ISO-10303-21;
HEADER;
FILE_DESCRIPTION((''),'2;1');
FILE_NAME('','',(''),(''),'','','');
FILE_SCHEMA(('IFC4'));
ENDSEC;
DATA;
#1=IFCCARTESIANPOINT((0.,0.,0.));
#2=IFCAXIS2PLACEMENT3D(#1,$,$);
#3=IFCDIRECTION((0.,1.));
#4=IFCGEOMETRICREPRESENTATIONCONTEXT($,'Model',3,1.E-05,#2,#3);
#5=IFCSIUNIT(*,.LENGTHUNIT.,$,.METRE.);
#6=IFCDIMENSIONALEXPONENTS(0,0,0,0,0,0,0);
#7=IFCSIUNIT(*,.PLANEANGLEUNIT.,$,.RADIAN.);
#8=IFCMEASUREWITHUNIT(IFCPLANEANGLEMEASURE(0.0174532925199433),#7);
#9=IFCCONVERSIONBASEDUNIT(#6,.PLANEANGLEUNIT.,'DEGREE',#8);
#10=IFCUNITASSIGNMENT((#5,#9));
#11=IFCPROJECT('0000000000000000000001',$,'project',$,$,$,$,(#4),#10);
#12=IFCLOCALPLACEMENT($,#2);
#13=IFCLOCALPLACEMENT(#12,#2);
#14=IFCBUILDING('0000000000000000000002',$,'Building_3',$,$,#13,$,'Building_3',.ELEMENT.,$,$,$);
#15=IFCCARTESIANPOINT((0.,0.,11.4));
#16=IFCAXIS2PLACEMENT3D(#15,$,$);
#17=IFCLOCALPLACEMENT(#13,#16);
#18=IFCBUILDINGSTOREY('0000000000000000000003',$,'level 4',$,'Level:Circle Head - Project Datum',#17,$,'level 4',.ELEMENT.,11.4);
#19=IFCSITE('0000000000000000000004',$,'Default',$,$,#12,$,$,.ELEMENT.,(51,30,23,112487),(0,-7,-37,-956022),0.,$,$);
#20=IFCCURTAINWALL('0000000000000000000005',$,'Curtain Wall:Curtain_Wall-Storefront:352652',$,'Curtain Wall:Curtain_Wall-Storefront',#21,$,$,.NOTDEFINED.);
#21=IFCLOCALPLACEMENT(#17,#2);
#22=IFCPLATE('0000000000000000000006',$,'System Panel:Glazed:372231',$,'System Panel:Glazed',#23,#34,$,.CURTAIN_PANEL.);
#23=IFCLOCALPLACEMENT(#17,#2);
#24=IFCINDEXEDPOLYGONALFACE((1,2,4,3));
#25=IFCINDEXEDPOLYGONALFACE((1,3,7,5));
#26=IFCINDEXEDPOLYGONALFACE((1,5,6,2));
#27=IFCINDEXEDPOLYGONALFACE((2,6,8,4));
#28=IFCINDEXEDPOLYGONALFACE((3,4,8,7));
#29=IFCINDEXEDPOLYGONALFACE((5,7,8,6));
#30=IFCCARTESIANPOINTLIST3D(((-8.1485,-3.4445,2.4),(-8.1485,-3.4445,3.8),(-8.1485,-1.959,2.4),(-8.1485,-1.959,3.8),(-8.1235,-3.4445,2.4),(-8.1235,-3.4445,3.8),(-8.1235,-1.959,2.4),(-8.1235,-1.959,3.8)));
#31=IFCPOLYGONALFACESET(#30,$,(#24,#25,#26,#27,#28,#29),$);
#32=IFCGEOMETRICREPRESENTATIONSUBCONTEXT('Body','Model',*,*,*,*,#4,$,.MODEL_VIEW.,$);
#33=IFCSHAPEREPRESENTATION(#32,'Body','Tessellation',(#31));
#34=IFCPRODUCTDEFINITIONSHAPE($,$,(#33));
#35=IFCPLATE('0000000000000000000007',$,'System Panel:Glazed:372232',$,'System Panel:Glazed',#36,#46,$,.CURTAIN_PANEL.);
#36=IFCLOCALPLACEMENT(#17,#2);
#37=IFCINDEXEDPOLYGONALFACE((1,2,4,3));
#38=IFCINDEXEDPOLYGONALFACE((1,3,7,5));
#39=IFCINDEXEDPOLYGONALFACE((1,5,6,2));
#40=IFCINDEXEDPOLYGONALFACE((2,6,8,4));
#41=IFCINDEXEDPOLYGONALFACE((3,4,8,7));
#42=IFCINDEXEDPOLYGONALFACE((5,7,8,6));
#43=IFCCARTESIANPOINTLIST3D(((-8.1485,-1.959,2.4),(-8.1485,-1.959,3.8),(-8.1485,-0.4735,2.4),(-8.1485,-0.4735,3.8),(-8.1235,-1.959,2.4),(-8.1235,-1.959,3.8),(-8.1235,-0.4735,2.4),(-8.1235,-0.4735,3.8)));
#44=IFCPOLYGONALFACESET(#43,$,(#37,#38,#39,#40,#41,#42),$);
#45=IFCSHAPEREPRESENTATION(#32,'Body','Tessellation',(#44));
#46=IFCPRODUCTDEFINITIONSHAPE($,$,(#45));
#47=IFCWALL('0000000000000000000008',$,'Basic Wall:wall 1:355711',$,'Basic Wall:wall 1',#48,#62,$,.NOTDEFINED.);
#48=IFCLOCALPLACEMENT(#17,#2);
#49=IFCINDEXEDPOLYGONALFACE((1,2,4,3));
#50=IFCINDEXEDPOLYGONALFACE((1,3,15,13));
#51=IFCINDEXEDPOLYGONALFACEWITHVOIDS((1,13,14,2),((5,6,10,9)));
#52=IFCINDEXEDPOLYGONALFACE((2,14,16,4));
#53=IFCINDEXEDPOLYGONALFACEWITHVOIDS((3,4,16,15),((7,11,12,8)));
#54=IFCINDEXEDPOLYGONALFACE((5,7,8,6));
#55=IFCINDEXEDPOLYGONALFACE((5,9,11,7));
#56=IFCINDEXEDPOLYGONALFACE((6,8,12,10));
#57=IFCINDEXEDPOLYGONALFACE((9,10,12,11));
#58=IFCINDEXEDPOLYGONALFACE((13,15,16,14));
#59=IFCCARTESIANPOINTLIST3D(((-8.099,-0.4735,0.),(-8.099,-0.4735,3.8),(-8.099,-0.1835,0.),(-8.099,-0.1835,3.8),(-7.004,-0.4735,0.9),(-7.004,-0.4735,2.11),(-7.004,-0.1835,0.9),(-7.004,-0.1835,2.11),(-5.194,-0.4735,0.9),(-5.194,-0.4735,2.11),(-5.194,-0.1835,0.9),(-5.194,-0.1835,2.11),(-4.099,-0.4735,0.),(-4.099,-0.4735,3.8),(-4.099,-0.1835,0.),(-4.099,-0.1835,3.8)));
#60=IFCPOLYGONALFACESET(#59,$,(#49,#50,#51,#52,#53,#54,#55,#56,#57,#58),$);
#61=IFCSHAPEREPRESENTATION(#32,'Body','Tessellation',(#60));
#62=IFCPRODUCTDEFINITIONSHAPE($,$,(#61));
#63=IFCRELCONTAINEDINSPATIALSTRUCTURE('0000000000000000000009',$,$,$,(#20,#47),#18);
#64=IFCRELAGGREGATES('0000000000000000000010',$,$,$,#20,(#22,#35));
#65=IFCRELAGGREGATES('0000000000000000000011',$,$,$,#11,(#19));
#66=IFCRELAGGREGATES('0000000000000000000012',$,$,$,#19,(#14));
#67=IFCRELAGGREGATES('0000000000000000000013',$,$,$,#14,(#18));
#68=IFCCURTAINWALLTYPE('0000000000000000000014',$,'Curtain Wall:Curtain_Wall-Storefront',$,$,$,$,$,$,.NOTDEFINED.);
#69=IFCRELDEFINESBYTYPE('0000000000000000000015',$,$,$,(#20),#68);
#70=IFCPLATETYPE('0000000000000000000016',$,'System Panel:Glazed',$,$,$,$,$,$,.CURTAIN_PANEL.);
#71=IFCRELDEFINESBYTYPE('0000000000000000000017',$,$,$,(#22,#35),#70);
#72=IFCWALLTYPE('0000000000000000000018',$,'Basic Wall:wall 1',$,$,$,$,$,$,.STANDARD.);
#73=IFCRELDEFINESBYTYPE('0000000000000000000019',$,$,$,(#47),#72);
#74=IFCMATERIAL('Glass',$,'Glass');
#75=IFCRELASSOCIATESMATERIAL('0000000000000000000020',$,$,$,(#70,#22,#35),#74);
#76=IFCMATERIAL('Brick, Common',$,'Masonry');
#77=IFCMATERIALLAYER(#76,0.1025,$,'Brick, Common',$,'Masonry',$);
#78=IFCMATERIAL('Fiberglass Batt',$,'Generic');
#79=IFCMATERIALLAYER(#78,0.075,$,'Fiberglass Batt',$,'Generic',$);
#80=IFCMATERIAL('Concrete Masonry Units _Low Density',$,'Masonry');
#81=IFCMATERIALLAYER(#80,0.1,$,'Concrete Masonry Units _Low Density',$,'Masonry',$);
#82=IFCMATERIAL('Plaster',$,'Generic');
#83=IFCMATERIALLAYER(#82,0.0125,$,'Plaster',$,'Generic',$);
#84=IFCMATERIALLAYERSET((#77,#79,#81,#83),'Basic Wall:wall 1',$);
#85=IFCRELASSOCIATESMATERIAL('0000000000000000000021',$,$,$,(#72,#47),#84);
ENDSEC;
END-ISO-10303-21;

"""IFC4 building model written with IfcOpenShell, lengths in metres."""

from ifc_helpers import new_model, entity, si_unit, converted_unit, direction, frame, frame_2d, origin, origin_2d_with_axis, place, context, subcontext, project, spatial, rectangle, extrude, source, transform, mapped, material, layer, layer_set, layer_usage, type_object, type_shapes, element, aggregate, save


model = new_model("IFC4")

# Units and contexts
model_context = context("Model", 3, precision=1e-05, world=origin(), true_north=direction((0.0, 1.0)))
body_context = subcontext(model_context, "Body", "Model", "MODEL_VIEW")
ifc_project = project(units=[si_unit("LENGTHUNIT", "METRE"), converted_unit("PLANEANGLEUNIT", "DEGREE", entity("IfcPlaneAngleMeasure", 0.0174532925199433), si_unit("PLANEANGLEUNIT", "RADIAN"), dimensions=[0, 0, 0, 0, 0, 0, 0])], contexts=[model_context])

# Site, building, storey
site_placement = place(None, origin())
site = spatial("IfcSite", under=ifc_project, at=site_placement, Name="Default", CompositionType="ELEMENT", RefLatitude=(51, 30, 23, 112487), RefLongitude=(0, -7, -37, -956022), RefElevation=0.0)
building_placement = place(site_placement, origin())
building = spatial("IfcBuilding", under=site, at=building_placement, Name="Building_3", LongName="Building_3", CompositionType="ELEMENT")
storey_placement = place(building_placement, frame((0.0, 0.0, 11.4)))
storey = spatial("IfcBuildingStorey", under=building, at=storey_placement, Name="level 4", ObjectType="Level:Circle Head - Project Datum", LongName="level 4", CompositionType="ELEMENT", Elevation=11.4)

# Curtain wall
curtain_wall_type = type_object("IfcCurtainWallType", Name="Curtain Wall:Curtain_Wall-Storefront", PredefinedType="NOTDEFINED")
ifc_material_1 = material(Name="Glass", Category="Glass")
curtain_wall_1_placement = place(storey_placement, frame((0.0, 0.0, -11.4)))
curtain_wall_1 = element("IfcCurtainWall", 1, at=curtain_wall_1_placement, inside=storey, type_object=curtain_wall_type, Name="Curtain Wall:Curtain_Wall-Storefront:352652", ObjectType="Curtain Wall:Curtain_Wall-Storefront", PredefinedType="NOTDEFINED")

# Plates
plate_type_1 = type_object("IfcPlateType", Name="System Panel:Glazed", PredefinedType="CURTAIN_PANEL", material=ifc_material_1)
shared_shape_1 = source(origin(), body_context, "Body", "SweptSolid", [
    extrude(rectangle(XDim=0.025, YDim=1.4855, at=origin_2d_with_axis()), frame((0.7428, 0.0125, 0.0), z_axis=(0.0, 0.0, 1.0), x_axis=(0.0, 1.0, 0.0)), (0.0, 0.0, 1.0), 1.4),
])
type_shapes(plate_type_1, [shared_shape_1])
plate_1_placement = place(curtain_wall_1_placement, frame((-8.1235, -3.4445, 13.8), z_axis=(0.0, 0.0, 1.0), x_axis=(0.0, 1.0, 0.0)))
plate_1 = element("IfcPlate", 2, at=plate_1_placement, type_object=plate_type_1, material=ifc_material_1, Name="System Panel:Glazed:372231", ObjectType="System Panel:Glazed", PredefinedType="CURTAIN_PANEL", context=body_context, shape_type="MappedRepresentation", body=[
    mapped(shared_shape_1, transform((0.0, 0.0, 0.0), scale=1.0)),
])
plate_2_placement = place(curtain_wall_1_placement, frame((-8.1235, -1.959, 13.8), z_axis=(0.0, 0.0, 1.0), x_axis=(0.0, 1.0, 0.0)))
plate_2 = element("IfcPlate", 3, at=plate_2_placement, type_object=plate_type_1, material=ifc_material_1, Name="System Panel:Glazed:372232", ObjectType="System Panel:Glazed", PredefinedType="CURTAIN_PANEL", context=body_context, shape_type="MappedRepresentation", body=[
    mapped(shared_shape_1, transform((0.0, 0.0, 0.0), scale=1.0)),
])
aggregate(curtain_wall_1, [plate_1, plate_2])

# Wall, opening
ifc_material_2 = material(Name="Brick, Common", Category="Masonry")
ifc_layer_1 = layer(ifc_material_2, 0.1025, Name="Brick, Common", Category="Masonry")
ifc_material_3 = material(Name="Fiberglass Batt", Category="Generic")
ifc_layer_2 = layer(ifc_material_3, 0.075, Name="Fiberglass Batt", Category="Generic")
ifc_material_4 = material(Name="Concrete Masonry Units _Low Density", Category="Masonry")
ifc_layer_3 = layer(ifc_material_4, 0.1, Name="Concrete Masonry Units _Low Density", Category="Masonry")
ifc_material_5 = material(Name="Plaster", Category="Generic")
ifc_layer_4 = layer(ifc_material_5, 0.0125, Name="Plaster", Category="Generic")
ifc_layer_set_1 = layer_set([ifc_layer_1, ifc_layer_2, ifc_layer_3, ifc_layer_4], Name="Basic Wall:wall 1")
ifc_layer_usage_1 = layer_usage(ifc_layer_set_1, "AXIS2", "NEGATIVE", 0.145)
wall_type = type_object("IfcWallType", Name="Basic Wall:wall 1", PredefinedType="STANDARD", material=ifc_layer_set_1)
wall_placement = place(storey_placement, frame((-8.099, -0.3285, 0.0)))
wall = element("IfcWall", 4, at=wall_placement, inside=storey, type_object=wall_type, material=ifc_layer_usage_1, Name="Basic Wall:wall 1:355711", ObjectType="Basic Wall:wall 1", PredefinedType="NOTDEFINED", context=body_context, shape_type="SweptSolid", body=[
    extrude(rectangle(XDim=4.0, YDim=0.29, at=frame_2d((2.0, 0.0), x_axis=(-1.0, 0.0))), origin(), (0.0, 0.0, 1.0), 3.8),
])
opening_1_placement = place(wall_placement, frame((1.095, -0.145, 0.9)))
element("IfcOpeningElement", 5, at=opening_1_placement, cuts=wall, PredefinedType="OPENING", context=body_context, shape_type="SweptSolid", body=[
    extrude(rectangle(XDim=1.21, YDim=1.81, at=frame_2d((0.605, 0.905), x_axis=(-1.0, 0.0))), frame((0.0, 0.0, 0.0), z_axis=(0.0, 1.0, 0.0), x_axis=(0.0, 0.0, 1.0)), (0.0, 0.0, 1.0), 0.29),
])

save(model, "model.ifc")
